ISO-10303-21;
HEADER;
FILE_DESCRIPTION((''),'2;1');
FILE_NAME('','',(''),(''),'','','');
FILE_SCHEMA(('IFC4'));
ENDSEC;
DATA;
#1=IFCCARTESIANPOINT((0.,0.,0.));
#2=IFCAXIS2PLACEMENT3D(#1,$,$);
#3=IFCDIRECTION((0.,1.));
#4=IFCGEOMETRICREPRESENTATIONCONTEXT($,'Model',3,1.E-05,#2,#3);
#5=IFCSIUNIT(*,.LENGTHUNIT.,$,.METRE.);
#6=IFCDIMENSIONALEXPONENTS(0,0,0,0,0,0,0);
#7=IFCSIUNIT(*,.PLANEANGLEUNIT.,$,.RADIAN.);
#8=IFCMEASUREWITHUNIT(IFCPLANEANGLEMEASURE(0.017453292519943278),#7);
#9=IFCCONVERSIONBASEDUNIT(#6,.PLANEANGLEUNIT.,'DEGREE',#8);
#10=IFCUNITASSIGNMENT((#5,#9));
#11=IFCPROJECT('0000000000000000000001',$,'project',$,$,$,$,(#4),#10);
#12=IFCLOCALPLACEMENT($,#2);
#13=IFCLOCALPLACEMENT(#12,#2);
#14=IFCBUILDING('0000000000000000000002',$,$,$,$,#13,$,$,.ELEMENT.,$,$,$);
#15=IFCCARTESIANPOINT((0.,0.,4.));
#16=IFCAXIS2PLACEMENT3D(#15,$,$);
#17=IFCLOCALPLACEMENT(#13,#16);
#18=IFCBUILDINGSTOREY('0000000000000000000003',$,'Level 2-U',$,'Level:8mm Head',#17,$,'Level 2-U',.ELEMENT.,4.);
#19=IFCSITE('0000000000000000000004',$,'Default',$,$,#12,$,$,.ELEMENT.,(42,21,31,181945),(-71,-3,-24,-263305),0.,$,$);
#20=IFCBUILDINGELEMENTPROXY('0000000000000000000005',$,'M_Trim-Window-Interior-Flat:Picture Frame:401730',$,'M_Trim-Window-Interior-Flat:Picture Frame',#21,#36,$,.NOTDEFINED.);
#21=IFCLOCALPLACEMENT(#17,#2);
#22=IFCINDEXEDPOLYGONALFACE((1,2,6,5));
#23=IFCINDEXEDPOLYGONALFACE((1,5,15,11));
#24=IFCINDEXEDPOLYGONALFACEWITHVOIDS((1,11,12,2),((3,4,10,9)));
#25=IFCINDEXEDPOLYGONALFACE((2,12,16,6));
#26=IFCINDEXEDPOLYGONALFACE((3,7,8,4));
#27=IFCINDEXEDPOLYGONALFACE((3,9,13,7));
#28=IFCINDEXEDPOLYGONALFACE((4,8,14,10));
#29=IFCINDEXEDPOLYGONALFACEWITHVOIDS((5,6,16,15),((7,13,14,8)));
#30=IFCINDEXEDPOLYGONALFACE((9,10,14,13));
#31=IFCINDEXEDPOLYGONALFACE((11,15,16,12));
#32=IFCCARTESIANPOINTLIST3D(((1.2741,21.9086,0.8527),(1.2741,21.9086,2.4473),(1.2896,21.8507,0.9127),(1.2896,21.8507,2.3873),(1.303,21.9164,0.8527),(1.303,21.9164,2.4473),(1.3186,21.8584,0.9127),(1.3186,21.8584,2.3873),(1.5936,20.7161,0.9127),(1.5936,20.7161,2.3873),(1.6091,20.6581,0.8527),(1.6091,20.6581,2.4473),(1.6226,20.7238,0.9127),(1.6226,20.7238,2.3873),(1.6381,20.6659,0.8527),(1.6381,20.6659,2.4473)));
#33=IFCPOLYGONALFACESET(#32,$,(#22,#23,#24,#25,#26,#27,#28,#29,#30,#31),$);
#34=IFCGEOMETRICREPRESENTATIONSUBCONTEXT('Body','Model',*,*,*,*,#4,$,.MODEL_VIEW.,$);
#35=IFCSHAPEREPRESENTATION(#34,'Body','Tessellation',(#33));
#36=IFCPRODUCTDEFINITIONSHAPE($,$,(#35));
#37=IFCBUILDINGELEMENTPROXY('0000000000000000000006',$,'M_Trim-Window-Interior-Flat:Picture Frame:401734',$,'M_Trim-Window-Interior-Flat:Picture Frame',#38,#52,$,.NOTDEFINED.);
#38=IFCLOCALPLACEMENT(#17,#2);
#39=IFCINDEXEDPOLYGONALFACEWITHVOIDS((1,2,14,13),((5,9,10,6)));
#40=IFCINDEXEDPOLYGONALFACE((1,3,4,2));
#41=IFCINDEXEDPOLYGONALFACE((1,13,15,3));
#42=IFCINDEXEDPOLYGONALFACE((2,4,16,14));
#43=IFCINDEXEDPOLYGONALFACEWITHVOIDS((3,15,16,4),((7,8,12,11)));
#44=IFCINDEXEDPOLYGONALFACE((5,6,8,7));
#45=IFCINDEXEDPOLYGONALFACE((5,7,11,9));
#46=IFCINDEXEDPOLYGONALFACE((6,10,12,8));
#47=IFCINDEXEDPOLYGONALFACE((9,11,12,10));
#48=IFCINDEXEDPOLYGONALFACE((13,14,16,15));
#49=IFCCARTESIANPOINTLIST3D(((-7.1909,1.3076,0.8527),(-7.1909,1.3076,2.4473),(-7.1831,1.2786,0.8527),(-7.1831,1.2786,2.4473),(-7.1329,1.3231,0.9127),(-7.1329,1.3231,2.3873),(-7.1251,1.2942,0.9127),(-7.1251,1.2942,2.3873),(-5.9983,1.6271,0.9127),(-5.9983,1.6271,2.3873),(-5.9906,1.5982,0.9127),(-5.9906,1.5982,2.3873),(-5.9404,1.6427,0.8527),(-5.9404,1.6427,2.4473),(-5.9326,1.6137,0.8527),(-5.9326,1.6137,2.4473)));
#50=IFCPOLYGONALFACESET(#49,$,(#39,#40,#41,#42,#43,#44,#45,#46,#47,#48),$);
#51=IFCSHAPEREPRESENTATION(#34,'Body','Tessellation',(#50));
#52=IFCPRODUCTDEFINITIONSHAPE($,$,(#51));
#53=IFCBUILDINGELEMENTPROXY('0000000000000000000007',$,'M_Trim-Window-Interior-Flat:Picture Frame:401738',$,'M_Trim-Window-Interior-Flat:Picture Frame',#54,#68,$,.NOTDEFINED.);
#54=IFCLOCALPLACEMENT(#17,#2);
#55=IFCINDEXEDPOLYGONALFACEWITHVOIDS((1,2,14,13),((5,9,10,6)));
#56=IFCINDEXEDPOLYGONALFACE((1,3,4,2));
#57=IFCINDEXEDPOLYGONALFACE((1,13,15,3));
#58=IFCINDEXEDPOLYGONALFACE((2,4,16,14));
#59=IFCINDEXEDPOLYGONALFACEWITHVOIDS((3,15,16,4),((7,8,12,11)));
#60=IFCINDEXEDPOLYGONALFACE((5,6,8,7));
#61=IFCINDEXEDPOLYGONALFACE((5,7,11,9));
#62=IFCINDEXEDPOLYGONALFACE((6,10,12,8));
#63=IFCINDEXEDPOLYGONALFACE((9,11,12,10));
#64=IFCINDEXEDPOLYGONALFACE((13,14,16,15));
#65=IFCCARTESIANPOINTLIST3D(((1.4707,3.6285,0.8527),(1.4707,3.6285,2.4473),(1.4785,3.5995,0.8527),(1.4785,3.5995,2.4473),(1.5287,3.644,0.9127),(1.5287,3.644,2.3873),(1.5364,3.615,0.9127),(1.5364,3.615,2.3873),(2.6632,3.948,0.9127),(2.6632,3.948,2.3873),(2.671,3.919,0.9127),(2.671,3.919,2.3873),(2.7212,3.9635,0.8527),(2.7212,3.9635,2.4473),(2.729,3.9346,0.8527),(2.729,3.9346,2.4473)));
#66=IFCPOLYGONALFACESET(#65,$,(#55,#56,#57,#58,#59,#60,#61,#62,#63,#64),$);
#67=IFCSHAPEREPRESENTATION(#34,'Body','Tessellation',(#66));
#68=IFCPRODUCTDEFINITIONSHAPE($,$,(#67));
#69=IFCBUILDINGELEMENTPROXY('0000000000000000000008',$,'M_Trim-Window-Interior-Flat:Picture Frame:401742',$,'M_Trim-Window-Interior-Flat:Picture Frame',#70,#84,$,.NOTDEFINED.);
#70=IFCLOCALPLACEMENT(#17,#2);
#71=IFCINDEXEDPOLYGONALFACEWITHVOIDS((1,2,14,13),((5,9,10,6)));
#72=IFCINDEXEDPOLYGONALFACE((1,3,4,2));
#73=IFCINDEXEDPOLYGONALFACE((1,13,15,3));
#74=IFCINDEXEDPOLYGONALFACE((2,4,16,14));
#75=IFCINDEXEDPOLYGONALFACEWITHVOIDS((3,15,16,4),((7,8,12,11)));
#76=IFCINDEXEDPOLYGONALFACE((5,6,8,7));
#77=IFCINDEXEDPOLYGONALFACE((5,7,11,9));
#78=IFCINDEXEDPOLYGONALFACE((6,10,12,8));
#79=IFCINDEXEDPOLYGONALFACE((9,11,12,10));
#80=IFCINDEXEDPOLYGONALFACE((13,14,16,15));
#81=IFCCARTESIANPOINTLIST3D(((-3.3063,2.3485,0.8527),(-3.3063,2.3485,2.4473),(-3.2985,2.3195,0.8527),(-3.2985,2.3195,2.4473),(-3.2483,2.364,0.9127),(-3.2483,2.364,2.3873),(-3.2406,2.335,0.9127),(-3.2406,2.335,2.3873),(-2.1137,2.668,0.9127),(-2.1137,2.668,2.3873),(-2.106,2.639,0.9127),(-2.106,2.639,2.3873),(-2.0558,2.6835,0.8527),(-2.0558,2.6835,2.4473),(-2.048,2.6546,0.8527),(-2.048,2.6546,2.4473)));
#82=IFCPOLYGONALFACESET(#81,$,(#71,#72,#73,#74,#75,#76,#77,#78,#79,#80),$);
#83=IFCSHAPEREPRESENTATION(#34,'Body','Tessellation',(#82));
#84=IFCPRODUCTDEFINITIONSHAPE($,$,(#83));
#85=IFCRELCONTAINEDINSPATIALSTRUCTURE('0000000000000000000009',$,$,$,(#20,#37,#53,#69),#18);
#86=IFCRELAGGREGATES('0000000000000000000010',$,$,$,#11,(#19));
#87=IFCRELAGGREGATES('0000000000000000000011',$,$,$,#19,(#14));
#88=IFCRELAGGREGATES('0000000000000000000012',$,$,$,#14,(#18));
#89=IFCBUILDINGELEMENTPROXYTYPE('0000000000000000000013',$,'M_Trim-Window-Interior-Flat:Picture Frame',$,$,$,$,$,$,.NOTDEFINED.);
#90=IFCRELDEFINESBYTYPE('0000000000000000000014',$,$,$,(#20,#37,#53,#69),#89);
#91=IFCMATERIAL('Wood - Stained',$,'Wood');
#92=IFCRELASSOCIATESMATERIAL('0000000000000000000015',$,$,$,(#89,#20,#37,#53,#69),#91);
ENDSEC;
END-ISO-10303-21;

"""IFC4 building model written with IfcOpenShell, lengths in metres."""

from ifc_helpers import new_model, entity, si_unit, converted_unit, direction, frame, origin, place, context, subcontext, project, spatial, polyline, outline, extrude, source, transform, mapped, material, type_object, type_shapes, element, save


model = new_model("IFC4")

# Units and contexts
model_context = context("Model", 3, precision=1e-05, world=origin(), true_north=direction((0.0, 1.0)))
body_context = subcontext(model_context, "Body", "Model", "MODEL_VIEW")
ifc_project = project(units=[si_unit("LENGTHUNIT", "METRE"), converted_unit("PLANEANGLEUNIT", "DEGREE", entity("IfcPlaneAngleMeasure", 0.017453292519943278), si_unit("PLANEANGLEUNIT", "RADIAN"), dimensions=[0, 0, 0, 0, 0, 0, 0])], contexts=[model_context])

# Site, building, storey
site_placement = place(None, origin())
site = spatial("IfcSite", under=ifc_project, at=site_placement, Name="Default", CompositionType="ELEMENT", RefLatitude=(42, 21, 31, 181945), RefLongitude=(-71, -3, -24, -263305), RefElevation=0.0)
building_placement = place(site_placement, origin())
building = spatial("IfcBuilding", under=site, at=building_placement, CompositionType="ELEMENT")
storey_placement = place(building_placement, frame((0.0, 0.0, 4.0)))
storey = spatial("IfcBuildingStorey", under=building, at=storey_placement, Name="Level 2-U", ObjectType="Level:8mm Head", LongName="Level 2-U", CompositionType="ELEMENT", Elevation=4.0)

# Building element proxies
ifc_material_1 = material(Name="Wood - Stained", Category="Wood")
building_element_proxy_type_1 = type_object("IfcBuildingElementProxyType", Name="M_Trim-Window-Interior-Flat:Picture Frame", PredefinedType="NOTDEFINED", material=ifc_material_1)
shared_shape_1 = source(origin(), body_context, "Body", "SweptSolid", [
    extrude(outline(polyline([(-0.6473, -0.7973), (0.6473, -0.7973), (0.6473, 0.7973), (-0.6473, 0.7973), (-0.6473, -0.7973)]), holes=[polyline([(-0.5873, -0.7373), (-0.5873, 0.7373), (0.5873, 0.7373), (0.5873, -0.7373), (-0.5873, -0.7373)])]), frame((0.0, -0.75, 0.0), z_axis=(0.0, 0.0, 1.0), x_axis=(-1.0, 0.0, 0.0)), (0.0, 0.0, 1.0), 0.03),
])
type_shapes(building_element_proxy_type_1, [shared_shape_1])
for number, where, z_axis, x_axis, name in (
    (1, (1.4706, 21.2911, 2.4), (-0.965926, -0.258819, 0.0), (0.258819, -0.965926, 0.0), "M_Trim-Window-Interior-Flat:Picture Frame:401730"),
    (2, (-6.5579, 1.4462, 2.4), (-0.258819, 0.965926, 0.0), (-0.965926, -0.258819, 0.0), "M_Trim-Window-Interior-Flat:Picture Frame:401734"),
    (3, (2.1037, 3.767, 2.4), (-0.258819, 0.965926, 0.0), (-0.965926, -0.258819, 0.0), "M_Trim-Window-Interior-Flat:Picture Frame:401738"),
    (4, (-2.6733, 2.487, 2.4), (-0.258819, 0.965926, 0.0), (-0.965926, -0.258819, 0.0), "M_Trim-Window-Interior-Flat:Picture Frame:401742"),
):
    element("IfcBuildingElementProxy", number, at=place(storey_placement, frame(where, z_axis=z_axis, x_axis=x_axis)), inside=storey, type_object=building_element_proxy_type_1, material=ifc_material_1, Name=name, ObjectType="M_Trim-Window-Interior-Flat:Picture Frame", PredefinedType="NOTDEFINED", context=body_context, shape_type="MappedRepresentation", body=[
        mapped(shared_shape_1, transform((0.0, 0.0, 0.0), scale=1.0)),
    ])

save(model, "model.ifc")
